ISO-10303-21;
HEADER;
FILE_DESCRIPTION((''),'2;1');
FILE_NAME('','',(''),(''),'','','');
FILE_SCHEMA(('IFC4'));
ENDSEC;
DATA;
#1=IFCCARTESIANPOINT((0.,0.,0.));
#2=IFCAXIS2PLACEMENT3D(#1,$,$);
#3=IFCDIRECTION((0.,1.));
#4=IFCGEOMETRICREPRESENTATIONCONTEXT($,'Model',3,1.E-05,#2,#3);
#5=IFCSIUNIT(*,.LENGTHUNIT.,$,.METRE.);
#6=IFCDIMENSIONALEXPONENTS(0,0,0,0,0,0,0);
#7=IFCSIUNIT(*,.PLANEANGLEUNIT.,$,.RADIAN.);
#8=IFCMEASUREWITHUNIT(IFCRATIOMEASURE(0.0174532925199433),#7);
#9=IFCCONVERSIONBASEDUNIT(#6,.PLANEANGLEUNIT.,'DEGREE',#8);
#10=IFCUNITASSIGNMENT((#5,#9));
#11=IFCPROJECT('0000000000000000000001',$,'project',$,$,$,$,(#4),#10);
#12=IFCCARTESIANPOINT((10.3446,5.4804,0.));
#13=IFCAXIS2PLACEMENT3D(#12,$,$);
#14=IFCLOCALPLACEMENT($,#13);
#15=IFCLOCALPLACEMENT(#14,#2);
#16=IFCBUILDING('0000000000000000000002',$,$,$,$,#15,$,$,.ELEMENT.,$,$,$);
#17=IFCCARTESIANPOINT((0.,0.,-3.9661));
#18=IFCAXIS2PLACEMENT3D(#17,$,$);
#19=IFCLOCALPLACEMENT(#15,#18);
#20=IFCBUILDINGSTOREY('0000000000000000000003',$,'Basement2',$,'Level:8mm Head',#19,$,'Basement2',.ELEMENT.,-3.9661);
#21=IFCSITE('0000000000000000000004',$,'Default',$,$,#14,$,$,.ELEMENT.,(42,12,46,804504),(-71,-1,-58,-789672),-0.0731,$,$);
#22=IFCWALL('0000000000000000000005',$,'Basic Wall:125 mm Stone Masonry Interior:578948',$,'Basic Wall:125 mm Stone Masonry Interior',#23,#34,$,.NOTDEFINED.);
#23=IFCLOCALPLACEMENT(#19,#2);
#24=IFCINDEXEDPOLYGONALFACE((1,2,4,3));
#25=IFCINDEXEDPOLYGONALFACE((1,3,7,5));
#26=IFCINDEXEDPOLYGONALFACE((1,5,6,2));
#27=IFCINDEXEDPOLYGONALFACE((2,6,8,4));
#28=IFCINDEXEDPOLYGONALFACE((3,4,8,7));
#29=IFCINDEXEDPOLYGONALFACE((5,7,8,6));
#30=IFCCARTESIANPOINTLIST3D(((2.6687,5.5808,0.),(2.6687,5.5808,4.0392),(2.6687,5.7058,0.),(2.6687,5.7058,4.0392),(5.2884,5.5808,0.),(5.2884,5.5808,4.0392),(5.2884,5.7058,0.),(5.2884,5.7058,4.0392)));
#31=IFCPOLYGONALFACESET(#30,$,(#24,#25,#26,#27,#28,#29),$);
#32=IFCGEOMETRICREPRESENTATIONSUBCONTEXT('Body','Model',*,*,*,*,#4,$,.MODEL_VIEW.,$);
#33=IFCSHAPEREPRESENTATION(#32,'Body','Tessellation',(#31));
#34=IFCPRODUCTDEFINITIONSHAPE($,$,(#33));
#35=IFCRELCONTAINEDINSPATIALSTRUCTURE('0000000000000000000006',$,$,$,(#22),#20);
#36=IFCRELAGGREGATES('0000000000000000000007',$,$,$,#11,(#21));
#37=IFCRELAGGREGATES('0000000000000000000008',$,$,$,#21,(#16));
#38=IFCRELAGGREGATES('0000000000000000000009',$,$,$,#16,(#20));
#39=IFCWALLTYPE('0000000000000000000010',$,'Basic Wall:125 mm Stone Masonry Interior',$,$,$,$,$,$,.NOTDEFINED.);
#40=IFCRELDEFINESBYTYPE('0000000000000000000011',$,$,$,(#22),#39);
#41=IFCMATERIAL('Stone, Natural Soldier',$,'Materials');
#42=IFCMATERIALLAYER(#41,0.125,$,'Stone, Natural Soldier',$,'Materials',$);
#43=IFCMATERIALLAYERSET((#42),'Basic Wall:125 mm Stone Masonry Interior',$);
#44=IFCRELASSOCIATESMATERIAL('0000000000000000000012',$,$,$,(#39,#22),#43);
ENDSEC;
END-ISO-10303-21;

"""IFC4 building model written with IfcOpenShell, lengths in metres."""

from ifc_helpers import new_model, entity, si_unit, converted_unit, direction, frame, frame_2d, origin, place, context, subcontext, project, spatial, rectangle, extrude, material, layer, layer_set, layer_usage, type_object, element, save


model = new_model("IFC4")

# Units and contexts
model_context = context("Model", 3, precision=1e-05, world=origin(), true_north=direction((0.0, 1.0)))
body_context = subcontext(model_context, "Body", "Model", "MODEL_VIEW")
ifc_project = project(units=[si_unit("LENGTHUNIT", "METRE"), converted_unit("PLANEANGLEUNIT", "DEGREE", entity("IfcRatioMeasure", 0.0174532925199433), si_unit("PLANEANGLEUNIT", "RADIAN"), dimensions=[0, 0, 0, 0, 0, 0, 0])], contexts=[model_context])

# Site, building, storey
site_placement = place(None, frame((10.3446, 5.4804, 0.0)))
site = spatial("IfcSite", under=ifc_project, at=site_placement, Name="Default", CompositionType="ELEMENT", RefLatitude=(42, 12, 46, 804504), RefLongitude=(-71, -1, -58, -789672), RefElevation=-0.0731)
building_placement = place(site_placement, origin())
building = spatial("IfcBuilding", under=site, at=building_placement, CompositionType="ELEMENT")
storey_placement = place(building_placement, frame((0.0, 0.0, -3.9661)))
storey = spatial("IfcBuildingStorey", under=building, at=storey_placement, Name="Basement2", ObjectType="Level:8mm Head", LongName="Basement2", CompositionType="ELEMENT", Elevation=-3.9661)

# Shared definitions
ifc_material_1 = material(Name="Stone, Natural Soldier", Category="Materials")

# Wall
ifc_layer_1 = layer(ifc_material_1, 0.125, Name="Stone, Natural Soldier", Category="Materials")
ifc_layer_set_1 = layer_set([ifc_layer_1], Name="Basic Wall:125 mm Stone Masonry Interior")
ifc_layer_usage_1 = layer_usage(ifc_layer_set_1, "AXIS2", "NEGATIVE", 0.0625)
wall_type_1 = type_object("IfcWallType", Name="Basic Wall:125 mm Stone Masonry Interior", PredefinedType="NOTDEFINED", material=ifc_layer_set_1)
wall_1_placement = place(storey_placement, frame((2.6687, 5.6433, 0.0)))
element("IfcWall", 1, at=wall_1_placement, inside=storey, type_object=wall_type_1, material=ifc_layer_usage_1, Name="Basic Wall:125 mm Stone Masonry Interior:578948", ObjectType="Basic Wall:125 mm Stone Masonry Interior", PredefinedType="NOTDEFINED", context=body_context, shape_type="SweptSolid", body=[
    extrude(rectangle(XDim=2.6197, YDim=0.125, at=frame_2d((1.3099, 0.0), x_axis=(-1.0, 0.0))), origin(), (0.0, 0.0, 1.0), 4.0392),
])

save(model, "model.ifc")
